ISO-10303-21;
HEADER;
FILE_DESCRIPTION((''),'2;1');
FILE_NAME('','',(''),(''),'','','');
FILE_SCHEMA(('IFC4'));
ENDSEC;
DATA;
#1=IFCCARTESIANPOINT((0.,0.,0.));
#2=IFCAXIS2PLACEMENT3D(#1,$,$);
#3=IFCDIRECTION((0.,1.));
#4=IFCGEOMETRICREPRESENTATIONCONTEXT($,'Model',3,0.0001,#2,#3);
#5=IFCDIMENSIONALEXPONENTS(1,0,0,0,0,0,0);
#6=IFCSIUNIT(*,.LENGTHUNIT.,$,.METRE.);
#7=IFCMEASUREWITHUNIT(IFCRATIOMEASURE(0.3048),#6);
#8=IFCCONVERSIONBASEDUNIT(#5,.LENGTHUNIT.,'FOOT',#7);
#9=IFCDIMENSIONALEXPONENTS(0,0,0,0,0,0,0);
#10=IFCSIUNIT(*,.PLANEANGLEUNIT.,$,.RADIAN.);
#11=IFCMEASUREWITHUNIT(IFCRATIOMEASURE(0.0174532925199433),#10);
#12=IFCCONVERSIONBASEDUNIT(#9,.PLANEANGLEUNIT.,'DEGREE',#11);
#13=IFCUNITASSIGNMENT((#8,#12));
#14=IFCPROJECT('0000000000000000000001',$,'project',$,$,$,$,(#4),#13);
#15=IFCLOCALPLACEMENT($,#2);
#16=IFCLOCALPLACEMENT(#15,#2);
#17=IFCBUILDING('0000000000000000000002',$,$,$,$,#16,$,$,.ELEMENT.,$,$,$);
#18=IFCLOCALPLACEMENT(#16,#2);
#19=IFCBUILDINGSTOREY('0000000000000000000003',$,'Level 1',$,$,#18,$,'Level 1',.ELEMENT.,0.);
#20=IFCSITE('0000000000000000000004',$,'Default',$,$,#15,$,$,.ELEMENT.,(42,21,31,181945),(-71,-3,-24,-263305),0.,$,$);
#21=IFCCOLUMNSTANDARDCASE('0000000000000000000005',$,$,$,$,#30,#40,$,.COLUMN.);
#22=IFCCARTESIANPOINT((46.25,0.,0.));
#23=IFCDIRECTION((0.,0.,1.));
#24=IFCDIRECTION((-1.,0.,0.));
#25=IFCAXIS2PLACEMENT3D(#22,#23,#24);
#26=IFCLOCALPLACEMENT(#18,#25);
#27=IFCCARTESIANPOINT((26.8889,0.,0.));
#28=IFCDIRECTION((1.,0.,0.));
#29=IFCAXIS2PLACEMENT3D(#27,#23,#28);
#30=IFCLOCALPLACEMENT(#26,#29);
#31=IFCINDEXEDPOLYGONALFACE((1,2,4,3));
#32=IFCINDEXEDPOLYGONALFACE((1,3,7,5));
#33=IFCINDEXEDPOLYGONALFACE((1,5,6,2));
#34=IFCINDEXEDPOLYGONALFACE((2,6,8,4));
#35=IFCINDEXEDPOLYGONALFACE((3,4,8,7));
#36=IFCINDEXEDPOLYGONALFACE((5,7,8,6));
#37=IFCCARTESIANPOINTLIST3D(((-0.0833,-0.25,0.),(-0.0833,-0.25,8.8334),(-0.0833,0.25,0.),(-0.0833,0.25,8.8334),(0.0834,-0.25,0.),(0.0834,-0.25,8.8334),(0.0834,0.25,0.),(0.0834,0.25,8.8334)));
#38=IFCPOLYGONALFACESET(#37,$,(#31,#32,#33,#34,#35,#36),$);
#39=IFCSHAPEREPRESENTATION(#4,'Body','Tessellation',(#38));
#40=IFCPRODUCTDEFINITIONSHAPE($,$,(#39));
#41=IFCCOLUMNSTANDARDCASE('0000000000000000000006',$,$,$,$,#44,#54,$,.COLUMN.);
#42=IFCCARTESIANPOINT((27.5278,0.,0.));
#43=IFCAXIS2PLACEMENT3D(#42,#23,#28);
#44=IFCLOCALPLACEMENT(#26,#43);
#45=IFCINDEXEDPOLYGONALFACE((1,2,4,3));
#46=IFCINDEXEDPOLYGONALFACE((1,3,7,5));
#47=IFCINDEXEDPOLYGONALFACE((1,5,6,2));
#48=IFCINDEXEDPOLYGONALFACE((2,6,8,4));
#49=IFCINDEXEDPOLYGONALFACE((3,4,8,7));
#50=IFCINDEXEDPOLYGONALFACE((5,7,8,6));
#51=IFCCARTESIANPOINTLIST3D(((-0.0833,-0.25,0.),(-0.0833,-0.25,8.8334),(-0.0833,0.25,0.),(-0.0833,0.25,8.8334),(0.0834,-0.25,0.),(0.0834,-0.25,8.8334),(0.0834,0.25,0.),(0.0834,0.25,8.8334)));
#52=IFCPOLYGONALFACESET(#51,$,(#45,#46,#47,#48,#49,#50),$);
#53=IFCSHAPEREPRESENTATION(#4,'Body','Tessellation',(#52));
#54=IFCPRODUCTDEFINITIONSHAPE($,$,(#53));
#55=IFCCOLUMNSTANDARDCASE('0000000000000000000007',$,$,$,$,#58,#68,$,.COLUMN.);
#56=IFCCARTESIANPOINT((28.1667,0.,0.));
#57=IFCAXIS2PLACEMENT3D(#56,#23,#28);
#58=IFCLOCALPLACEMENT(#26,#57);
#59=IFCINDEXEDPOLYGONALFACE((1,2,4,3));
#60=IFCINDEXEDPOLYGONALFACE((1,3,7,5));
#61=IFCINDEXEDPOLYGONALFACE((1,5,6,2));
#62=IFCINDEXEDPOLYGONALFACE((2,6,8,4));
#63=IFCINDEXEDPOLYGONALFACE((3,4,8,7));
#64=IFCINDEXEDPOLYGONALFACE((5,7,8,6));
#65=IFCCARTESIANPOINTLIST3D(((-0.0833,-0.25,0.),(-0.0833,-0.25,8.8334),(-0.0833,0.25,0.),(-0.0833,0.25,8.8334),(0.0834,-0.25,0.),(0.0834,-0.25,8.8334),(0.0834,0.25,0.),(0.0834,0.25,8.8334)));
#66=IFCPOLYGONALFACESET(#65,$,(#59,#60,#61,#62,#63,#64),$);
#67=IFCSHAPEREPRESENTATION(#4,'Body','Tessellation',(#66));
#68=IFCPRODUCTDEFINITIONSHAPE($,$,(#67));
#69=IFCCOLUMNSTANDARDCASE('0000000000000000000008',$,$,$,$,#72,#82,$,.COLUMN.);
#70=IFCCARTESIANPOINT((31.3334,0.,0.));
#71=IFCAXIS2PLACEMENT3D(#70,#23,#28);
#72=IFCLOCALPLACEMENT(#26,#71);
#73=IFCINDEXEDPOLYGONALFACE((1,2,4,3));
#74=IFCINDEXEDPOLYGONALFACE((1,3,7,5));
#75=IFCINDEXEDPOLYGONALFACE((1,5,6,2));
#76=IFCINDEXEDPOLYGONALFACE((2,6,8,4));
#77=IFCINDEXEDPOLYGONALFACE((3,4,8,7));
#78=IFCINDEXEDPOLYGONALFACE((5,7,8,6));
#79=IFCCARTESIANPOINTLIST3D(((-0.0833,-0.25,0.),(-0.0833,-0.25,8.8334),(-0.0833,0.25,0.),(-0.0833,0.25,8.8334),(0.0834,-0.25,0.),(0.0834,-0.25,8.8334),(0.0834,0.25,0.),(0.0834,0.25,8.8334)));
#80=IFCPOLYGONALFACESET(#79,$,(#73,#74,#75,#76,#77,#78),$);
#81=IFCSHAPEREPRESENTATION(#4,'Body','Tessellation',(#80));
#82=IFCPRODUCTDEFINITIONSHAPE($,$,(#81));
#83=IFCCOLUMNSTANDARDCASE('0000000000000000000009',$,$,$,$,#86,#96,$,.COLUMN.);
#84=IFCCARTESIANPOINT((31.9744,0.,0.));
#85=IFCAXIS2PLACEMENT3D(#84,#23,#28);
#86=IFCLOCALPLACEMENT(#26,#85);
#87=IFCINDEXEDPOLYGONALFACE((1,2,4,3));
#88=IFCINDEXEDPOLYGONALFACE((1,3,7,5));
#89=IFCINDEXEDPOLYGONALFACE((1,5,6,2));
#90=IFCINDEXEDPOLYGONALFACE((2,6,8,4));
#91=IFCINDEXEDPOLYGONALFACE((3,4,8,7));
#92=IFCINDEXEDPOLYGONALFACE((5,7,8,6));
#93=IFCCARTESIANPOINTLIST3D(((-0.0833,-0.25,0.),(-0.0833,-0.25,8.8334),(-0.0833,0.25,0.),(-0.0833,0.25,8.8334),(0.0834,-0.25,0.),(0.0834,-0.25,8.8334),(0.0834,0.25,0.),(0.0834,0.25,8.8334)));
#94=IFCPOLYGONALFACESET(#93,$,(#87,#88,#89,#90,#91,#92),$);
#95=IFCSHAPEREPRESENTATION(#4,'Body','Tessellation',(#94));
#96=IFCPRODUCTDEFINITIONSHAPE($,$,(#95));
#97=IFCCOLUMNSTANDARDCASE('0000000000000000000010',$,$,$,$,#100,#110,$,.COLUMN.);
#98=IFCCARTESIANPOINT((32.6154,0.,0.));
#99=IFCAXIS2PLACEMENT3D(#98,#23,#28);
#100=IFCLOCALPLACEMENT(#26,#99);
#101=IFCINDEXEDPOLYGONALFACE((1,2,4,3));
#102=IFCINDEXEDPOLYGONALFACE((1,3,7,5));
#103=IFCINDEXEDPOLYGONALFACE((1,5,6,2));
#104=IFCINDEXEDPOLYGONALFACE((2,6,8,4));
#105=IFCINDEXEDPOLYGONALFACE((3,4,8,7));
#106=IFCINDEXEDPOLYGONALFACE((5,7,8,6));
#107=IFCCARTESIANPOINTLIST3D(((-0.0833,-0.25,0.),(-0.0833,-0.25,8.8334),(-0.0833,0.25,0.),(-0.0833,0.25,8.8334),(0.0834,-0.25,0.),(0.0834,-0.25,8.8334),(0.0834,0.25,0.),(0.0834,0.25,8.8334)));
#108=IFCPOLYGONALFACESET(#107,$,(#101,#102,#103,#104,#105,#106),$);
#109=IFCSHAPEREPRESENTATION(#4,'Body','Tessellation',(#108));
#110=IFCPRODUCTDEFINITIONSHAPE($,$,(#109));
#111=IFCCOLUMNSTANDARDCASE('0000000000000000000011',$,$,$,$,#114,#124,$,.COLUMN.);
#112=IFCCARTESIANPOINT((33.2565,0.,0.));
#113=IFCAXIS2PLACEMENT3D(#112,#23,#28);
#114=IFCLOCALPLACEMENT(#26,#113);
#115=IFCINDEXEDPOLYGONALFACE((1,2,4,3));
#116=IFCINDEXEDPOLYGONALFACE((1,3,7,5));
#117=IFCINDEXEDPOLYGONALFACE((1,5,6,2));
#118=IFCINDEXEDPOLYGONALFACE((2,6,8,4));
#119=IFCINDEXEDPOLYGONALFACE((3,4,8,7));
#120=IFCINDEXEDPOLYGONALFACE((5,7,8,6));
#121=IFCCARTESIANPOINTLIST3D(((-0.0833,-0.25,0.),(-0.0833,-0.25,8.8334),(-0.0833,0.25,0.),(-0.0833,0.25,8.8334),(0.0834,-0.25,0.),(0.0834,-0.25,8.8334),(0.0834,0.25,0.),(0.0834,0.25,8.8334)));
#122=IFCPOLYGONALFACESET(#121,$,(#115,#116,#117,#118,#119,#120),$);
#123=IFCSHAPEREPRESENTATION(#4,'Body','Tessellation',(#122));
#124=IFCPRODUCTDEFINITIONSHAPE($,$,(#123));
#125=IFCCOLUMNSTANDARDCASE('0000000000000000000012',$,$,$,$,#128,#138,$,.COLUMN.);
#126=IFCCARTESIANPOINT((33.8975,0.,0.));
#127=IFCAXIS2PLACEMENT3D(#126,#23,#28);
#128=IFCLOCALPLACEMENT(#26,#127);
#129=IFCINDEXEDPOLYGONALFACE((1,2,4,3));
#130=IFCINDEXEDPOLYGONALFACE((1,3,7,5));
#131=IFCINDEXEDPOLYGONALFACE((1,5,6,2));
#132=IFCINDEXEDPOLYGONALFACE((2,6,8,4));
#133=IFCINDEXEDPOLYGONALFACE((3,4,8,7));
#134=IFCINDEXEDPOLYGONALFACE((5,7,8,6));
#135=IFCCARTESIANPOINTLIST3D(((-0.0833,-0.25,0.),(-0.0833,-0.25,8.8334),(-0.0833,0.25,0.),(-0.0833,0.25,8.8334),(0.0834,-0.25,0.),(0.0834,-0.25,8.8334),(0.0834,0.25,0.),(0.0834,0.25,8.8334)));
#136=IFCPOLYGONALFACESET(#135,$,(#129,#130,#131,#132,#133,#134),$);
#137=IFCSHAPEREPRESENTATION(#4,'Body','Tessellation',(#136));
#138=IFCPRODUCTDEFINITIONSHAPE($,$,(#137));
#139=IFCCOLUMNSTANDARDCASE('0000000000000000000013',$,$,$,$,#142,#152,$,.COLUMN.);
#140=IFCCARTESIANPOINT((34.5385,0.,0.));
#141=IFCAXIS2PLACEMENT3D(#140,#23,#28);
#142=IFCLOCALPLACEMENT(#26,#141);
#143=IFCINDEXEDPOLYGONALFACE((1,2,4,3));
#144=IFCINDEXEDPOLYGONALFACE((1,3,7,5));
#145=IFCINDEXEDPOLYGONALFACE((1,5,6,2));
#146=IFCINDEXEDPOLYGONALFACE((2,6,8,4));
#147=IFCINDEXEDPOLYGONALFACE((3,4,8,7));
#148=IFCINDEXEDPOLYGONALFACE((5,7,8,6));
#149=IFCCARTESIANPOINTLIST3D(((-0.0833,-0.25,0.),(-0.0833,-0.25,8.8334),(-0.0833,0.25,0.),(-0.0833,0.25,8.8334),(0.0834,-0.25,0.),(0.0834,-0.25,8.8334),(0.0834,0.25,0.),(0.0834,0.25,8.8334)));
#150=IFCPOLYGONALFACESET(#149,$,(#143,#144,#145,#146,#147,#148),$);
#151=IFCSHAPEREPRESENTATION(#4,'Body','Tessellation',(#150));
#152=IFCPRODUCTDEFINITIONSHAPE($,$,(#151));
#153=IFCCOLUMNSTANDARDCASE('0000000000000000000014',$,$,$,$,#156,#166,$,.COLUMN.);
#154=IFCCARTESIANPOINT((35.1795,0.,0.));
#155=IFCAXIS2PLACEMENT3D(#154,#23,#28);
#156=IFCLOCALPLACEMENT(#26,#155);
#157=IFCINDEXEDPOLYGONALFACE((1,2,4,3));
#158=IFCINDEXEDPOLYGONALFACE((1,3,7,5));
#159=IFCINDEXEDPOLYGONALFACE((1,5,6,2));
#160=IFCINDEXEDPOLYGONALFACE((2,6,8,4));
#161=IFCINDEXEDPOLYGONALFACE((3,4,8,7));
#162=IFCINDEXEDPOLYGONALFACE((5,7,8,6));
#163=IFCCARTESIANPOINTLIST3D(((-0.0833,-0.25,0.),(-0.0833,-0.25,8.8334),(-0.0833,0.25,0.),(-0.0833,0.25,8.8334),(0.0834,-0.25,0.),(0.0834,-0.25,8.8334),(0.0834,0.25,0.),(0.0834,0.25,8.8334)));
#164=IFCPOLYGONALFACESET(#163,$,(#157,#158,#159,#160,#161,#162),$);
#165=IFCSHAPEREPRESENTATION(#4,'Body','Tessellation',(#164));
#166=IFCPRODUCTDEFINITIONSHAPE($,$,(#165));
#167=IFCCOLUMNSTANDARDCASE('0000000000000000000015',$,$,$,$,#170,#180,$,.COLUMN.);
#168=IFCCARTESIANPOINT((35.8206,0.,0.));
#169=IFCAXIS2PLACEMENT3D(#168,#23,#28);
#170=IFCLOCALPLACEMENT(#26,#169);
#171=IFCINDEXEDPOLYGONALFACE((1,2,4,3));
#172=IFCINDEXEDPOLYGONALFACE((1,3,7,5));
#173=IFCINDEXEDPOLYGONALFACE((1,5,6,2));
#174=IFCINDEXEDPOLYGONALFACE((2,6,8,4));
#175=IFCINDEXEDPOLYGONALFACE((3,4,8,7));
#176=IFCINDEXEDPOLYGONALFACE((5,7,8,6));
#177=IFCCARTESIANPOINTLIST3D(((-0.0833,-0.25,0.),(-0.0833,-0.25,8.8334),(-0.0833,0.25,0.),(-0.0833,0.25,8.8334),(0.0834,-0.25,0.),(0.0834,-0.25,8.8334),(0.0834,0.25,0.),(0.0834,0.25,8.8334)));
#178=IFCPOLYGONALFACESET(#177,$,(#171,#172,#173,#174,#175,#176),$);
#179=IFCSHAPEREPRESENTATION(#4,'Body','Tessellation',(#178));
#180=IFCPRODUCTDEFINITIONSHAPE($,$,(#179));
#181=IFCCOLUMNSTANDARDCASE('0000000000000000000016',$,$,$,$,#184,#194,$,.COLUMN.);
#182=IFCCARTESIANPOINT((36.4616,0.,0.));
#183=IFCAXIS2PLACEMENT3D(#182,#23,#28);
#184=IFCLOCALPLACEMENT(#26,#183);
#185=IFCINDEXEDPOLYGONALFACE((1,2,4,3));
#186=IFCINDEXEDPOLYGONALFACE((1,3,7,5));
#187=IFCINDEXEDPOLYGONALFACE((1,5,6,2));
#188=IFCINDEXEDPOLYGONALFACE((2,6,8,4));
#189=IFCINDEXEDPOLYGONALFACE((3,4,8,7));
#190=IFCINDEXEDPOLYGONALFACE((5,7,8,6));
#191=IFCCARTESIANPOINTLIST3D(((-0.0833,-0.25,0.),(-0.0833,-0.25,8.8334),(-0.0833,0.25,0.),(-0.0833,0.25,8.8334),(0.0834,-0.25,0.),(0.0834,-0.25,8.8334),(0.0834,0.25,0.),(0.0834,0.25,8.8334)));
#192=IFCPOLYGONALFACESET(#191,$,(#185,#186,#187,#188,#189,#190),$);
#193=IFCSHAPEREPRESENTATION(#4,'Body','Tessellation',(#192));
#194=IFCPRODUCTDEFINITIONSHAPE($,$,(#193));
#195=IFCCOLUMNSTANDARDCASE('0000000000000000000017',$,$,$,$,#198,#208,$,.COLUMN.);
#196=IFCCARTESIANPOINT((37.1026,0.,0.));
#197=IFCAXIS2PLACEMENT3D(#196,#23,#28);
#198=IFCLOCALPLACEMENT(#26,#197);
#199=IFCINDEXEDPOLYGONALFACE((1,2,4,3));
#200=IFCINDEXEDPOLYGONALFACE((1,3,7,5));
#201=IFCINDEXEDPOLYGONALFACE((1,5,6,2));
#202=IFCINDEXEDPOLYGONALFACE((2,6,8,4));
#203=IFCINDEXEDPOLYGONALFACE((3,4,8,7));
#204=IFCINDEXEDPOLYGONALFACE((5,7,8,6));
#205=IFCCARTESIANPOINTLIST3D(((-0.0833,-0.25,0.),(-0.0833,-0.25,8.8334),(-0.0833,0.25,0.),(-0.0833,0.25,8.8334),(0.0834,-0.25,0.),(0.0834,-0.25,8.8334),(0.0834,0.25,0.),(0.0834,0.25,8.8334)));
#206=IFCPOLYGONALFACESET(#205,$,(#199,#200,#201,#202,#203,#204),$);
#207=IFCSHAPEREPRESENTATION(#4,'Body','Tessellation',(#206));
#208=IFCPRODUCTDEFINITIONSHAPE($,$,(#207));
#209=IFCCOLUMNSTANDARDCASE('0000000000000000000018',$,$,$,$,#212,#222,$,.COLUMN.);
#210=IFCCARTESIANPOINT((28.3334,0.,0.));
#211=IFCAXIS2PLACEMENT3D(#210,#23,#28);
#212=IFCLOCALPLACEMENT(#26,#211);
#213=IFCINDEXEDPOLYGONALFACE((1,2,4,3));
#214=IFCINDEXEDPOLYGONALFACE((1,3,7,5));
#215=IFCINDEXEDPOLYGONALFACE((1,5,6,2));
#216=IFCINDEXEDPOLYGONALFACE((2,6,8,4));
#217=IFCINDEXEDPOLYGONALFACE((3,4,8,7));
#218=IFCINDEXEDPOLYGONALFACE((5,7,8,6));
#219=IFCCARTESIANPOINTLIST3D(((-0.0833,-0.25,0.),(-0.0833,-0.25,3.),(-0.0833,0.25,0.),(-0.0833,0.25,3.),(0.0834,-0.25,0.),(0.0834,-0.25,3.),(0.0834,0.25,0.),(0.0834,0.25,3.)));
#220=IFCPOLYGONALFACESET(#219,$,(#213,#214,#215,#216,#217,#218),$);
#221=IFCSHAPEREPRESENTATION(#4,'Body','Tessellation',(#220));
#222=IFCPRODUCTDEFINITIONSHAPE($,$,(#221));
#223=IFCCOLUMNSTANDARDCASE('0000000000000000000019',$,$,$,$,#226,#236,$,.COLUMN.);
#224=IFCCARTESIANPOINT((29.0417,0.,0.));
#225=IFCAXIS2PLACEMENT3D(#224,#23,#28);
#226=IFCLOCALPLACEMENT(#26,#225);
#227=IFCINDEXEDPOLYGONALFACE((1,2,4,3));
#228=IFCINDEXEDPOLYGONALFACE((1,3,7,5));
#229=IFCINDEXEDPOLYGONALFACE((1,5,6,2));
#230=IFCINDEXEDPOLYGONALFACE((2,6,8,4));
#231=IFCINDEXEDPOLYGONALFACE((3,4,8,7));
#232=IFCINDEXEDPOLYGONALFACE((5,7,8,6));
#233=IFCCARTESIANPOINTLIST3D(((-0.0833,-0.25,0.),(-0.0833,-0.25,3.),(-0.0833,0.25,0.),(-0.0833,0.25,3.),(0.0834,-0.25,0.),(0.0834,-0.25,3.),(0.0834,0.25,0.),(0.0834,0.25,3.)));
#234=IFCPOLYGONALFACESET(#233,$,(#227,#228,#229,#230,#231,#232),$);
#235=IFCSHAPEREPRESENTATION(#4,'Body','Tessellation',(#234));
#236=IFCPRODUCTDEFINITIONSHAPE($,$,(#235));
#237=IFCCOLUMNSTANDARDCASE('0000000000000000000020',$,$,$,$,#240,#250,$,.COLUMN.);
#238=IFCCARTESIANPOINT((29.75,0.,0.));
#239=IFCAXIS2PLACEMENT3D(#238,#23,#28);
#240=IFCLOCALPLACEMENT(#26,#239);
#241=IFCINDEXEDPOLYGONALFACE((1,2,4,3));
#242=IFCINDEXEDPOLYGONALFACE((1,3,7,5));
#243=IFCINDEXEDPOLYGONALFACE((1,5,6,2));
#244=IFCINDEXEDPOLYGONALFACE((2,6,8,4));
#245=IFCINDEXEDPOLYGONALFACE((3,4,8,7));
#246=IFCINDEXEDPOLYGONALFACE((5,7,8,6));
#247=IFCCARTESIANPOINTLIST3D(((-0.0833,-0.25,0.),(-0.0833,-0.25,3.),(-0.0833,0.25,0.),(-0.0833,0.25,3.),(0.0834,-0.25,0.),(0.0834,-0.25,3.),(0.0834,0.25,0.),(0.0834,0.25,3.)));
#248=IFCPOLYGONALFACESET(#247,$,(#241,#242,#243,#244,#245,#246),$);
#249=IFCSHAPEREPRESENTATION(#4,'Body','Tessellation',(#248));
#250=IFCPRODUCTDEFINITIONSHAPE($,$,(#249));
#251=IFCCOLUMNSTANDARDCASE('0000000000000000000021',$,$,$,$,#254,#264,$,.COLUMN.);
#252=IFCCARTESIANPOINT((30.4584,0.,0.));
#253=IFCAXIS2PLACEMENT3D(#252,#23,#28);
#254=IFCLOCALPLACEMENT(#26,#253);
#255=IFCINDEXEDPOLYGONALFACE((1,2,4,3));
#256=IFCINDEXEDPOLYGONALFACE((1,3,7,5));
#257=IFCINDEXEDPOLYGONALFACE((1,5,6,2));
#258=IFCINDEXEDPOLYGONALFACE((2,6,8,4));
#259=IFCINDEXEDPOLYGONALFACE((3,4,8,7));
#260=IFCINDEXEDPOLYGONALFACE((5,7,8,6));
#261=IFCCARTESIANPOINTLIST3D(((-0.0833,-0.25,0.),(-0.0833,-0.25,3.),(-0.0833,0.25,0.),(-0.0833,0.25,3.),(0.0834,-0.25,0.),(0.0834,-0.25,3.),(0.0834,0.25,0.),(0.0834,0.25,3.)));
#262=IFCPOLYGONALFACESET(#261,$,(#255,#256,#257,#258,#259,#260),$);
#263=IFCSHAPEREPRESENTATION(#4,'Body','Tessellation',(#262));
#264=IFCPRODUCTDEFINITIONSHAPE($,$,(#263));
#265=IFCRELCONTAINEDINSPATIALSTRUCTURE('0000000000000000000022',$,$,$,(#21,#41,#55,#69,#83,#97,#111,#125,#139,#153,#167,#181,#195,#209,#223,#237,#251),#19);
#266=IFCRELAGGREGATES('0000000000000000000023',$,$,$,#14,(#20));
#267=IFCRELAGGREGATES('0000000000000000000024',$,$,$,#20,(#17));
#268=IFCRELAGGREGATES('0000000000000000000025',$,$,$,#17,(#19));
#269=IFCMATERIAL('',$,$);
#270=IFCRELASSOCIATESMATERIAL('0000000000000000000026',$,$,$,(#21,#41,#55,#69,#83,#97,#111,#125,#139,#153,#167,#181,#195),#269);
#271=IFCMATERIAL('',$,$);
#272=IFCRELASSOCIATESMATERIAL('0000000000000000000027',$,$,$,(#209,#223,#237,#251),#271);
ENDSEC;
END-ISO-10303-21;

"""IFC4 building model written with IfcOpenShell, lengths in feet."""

from ifc_helpers import new_model, entity, si_unit, converted_unit, direction, frame, origin, place, context, project, spatial, rectangle, extrude, material, element, save


model = new_model("IFC4")

# Units and contexts
model_context = context("Model", 3, precision=0.0001, world=origin(), true_north=direction((0.0, 1.0)))
ifc_project = project(units=[converted_unit("LENGTHUNIT", "FOOT", entity("IfcRatioMeasure", 0.3048), si_unit("LENGTHUNIT", "METRE"), dimensions=[1, 0, 0, 0, 0, 0, 0]), converted_unit("PLANEANGLEUNIT", "DEGREE", entity("IfcRatioMeasure", 0.0174532925199433), si_unit("PLANEANGLEUNIT", "RADIAN"), dimensions=[0, 0, 0, 0, 0, 0, 0])], contexts=[model_context])

# Site, building, storey
site_placement = place(None, origin())
site = spatial("IfcSite", under=ifc_project, at=site_placement, Name="Default", CompositionType="ELEMENT", RefLatitude=(42, 21, 31, 181945), RefLongitude=(-71, -3, -24, -263305), RefElevation=0.0)
building_placement = place(site_placement, origin())
building = spatial("IfcBuilding", under=site, at=building_placement, CompositionType="ELEMENT")
storey_placement = place(building_placement, origin())
storey = spatial("IfcBuildingStorey", under=building, at=storey_placement, Name="Level 1", LongName="Level 1", CompositionType="ELEMENT", Elevation=0.0)

# Columns
ifc_material_1 = material(Name="")
placement_1 = place(storey_placement, frame((46.25, 0.0, 0.0), z_axis=(0.0, 0.0, 1.0), x_axis=(-1.0, 0.0, 0.0)))
for number, where, z_axis, x_axis in (
    (1, (26.8889, 0.0, 0.0), (0.0, 0.0, 1.0), (1.0, 0.0, 0.0)),
    (2, (27.5278, 0.0, 0.0), (0.0, 0.0, 1.0), (1.0, 0.0, 0.0)),
    (3, (28.1667, 0.0, 0.0), (0.0, 0.0, 1.0), (1.0, 0.0, 0.0)),
    (4, (31.3334, 0.0, 0.0), (0.0, 0.0, 1.0), (1.0, 0.0, 0.0)),
    (5, (31.9744, 0.0, 0.0), (0.0, 0.0, 1.0), (1.0, 0.0, 0.0)),
    (6, (32.6154, 0.0, 0.0), (0.0, 0.0, 1.0), (1.0, 0.0, 0.0)),
    (7, (33.2565, 0.0, 0.0), (0.0, 0.0, 1.0), (1.0, 0.0, 0.0)),
    (8, (33.8975, 0.0, 0.0), (0.0, 0.0, 1.0), (1.0, 0.0, 0.0)),
    (9, (34.5385, 0.0, 0.0), (0.0, 0.0, 1.0), (1.0, 0.0, 0.0)),
    (10, (35.1795, 0.0, 0.0), (0.0, 0.0, 1.0), (1.0, 0.0, 0.0)),
    (11, (35.8206, 0.0, 0.0), (0.0, 0.0, 1.0), (1.0, 0.0, 0.0)),
    (12, (36.4616, 0.0, 0.0), (0.0, 0.0, 1.0), (1.0, 0.0, 0.0)),
    (13, (37.1026, 0.0, 0.0), (0.0, 0.0, 1.0), (1.0, 0.0, 0.0)),
):
    element("IfcColumnStandardCase", number, at=place(placement_1, frame(where, z_axis=z_axis, x_axis=x_axis)), inside=storey, material=ifc_material_1, PredefinedType="COLUMN", context=model_context, shape_type="SweptSolid", body=[
        extrude(rectangle(XDim=0.1667, YDim=0.5), origin(), (0.0, 0.0, 1.0), 8.8334),
    ])
ifc_material_2 = material(Name="")
for number, where, z_axis, x_axis in (
    (14, (28.3334, 0.0, 0.0), (0.0, 0.0, 1.0), (1.0, 0.0, 0.0)),
    (15, (29.0417, 0.0, 0.0), (0.0, 0.0, 1.0), (1.0, 0.0, 0.0)),
    (16, (29.75, 0.0, 0.0), (0.0, 0.0, 1.0), (1.0, 0.0, 0.0)),
    (17, (30.4584, 0.0, 0.0), (0.0, 0.0, 1.0), (1.0, 0.0, 0.0)),
):
    element("IfcColumnStandardCase", number, at=place(placement_1, frame(where, z_axis=z_axis, x_axis=x_axis)), inside=storey, material=ifc_material_2, PredefinedType="COLUMN", context=model_context, shape_type="SweptSolid", body=[
        extrude(rectangle(XDim=0.1667, YDim=0.5), origin(), (0.0, 0.0, 1.0), 3.0),
    ])

save(model, "model.ifc")
